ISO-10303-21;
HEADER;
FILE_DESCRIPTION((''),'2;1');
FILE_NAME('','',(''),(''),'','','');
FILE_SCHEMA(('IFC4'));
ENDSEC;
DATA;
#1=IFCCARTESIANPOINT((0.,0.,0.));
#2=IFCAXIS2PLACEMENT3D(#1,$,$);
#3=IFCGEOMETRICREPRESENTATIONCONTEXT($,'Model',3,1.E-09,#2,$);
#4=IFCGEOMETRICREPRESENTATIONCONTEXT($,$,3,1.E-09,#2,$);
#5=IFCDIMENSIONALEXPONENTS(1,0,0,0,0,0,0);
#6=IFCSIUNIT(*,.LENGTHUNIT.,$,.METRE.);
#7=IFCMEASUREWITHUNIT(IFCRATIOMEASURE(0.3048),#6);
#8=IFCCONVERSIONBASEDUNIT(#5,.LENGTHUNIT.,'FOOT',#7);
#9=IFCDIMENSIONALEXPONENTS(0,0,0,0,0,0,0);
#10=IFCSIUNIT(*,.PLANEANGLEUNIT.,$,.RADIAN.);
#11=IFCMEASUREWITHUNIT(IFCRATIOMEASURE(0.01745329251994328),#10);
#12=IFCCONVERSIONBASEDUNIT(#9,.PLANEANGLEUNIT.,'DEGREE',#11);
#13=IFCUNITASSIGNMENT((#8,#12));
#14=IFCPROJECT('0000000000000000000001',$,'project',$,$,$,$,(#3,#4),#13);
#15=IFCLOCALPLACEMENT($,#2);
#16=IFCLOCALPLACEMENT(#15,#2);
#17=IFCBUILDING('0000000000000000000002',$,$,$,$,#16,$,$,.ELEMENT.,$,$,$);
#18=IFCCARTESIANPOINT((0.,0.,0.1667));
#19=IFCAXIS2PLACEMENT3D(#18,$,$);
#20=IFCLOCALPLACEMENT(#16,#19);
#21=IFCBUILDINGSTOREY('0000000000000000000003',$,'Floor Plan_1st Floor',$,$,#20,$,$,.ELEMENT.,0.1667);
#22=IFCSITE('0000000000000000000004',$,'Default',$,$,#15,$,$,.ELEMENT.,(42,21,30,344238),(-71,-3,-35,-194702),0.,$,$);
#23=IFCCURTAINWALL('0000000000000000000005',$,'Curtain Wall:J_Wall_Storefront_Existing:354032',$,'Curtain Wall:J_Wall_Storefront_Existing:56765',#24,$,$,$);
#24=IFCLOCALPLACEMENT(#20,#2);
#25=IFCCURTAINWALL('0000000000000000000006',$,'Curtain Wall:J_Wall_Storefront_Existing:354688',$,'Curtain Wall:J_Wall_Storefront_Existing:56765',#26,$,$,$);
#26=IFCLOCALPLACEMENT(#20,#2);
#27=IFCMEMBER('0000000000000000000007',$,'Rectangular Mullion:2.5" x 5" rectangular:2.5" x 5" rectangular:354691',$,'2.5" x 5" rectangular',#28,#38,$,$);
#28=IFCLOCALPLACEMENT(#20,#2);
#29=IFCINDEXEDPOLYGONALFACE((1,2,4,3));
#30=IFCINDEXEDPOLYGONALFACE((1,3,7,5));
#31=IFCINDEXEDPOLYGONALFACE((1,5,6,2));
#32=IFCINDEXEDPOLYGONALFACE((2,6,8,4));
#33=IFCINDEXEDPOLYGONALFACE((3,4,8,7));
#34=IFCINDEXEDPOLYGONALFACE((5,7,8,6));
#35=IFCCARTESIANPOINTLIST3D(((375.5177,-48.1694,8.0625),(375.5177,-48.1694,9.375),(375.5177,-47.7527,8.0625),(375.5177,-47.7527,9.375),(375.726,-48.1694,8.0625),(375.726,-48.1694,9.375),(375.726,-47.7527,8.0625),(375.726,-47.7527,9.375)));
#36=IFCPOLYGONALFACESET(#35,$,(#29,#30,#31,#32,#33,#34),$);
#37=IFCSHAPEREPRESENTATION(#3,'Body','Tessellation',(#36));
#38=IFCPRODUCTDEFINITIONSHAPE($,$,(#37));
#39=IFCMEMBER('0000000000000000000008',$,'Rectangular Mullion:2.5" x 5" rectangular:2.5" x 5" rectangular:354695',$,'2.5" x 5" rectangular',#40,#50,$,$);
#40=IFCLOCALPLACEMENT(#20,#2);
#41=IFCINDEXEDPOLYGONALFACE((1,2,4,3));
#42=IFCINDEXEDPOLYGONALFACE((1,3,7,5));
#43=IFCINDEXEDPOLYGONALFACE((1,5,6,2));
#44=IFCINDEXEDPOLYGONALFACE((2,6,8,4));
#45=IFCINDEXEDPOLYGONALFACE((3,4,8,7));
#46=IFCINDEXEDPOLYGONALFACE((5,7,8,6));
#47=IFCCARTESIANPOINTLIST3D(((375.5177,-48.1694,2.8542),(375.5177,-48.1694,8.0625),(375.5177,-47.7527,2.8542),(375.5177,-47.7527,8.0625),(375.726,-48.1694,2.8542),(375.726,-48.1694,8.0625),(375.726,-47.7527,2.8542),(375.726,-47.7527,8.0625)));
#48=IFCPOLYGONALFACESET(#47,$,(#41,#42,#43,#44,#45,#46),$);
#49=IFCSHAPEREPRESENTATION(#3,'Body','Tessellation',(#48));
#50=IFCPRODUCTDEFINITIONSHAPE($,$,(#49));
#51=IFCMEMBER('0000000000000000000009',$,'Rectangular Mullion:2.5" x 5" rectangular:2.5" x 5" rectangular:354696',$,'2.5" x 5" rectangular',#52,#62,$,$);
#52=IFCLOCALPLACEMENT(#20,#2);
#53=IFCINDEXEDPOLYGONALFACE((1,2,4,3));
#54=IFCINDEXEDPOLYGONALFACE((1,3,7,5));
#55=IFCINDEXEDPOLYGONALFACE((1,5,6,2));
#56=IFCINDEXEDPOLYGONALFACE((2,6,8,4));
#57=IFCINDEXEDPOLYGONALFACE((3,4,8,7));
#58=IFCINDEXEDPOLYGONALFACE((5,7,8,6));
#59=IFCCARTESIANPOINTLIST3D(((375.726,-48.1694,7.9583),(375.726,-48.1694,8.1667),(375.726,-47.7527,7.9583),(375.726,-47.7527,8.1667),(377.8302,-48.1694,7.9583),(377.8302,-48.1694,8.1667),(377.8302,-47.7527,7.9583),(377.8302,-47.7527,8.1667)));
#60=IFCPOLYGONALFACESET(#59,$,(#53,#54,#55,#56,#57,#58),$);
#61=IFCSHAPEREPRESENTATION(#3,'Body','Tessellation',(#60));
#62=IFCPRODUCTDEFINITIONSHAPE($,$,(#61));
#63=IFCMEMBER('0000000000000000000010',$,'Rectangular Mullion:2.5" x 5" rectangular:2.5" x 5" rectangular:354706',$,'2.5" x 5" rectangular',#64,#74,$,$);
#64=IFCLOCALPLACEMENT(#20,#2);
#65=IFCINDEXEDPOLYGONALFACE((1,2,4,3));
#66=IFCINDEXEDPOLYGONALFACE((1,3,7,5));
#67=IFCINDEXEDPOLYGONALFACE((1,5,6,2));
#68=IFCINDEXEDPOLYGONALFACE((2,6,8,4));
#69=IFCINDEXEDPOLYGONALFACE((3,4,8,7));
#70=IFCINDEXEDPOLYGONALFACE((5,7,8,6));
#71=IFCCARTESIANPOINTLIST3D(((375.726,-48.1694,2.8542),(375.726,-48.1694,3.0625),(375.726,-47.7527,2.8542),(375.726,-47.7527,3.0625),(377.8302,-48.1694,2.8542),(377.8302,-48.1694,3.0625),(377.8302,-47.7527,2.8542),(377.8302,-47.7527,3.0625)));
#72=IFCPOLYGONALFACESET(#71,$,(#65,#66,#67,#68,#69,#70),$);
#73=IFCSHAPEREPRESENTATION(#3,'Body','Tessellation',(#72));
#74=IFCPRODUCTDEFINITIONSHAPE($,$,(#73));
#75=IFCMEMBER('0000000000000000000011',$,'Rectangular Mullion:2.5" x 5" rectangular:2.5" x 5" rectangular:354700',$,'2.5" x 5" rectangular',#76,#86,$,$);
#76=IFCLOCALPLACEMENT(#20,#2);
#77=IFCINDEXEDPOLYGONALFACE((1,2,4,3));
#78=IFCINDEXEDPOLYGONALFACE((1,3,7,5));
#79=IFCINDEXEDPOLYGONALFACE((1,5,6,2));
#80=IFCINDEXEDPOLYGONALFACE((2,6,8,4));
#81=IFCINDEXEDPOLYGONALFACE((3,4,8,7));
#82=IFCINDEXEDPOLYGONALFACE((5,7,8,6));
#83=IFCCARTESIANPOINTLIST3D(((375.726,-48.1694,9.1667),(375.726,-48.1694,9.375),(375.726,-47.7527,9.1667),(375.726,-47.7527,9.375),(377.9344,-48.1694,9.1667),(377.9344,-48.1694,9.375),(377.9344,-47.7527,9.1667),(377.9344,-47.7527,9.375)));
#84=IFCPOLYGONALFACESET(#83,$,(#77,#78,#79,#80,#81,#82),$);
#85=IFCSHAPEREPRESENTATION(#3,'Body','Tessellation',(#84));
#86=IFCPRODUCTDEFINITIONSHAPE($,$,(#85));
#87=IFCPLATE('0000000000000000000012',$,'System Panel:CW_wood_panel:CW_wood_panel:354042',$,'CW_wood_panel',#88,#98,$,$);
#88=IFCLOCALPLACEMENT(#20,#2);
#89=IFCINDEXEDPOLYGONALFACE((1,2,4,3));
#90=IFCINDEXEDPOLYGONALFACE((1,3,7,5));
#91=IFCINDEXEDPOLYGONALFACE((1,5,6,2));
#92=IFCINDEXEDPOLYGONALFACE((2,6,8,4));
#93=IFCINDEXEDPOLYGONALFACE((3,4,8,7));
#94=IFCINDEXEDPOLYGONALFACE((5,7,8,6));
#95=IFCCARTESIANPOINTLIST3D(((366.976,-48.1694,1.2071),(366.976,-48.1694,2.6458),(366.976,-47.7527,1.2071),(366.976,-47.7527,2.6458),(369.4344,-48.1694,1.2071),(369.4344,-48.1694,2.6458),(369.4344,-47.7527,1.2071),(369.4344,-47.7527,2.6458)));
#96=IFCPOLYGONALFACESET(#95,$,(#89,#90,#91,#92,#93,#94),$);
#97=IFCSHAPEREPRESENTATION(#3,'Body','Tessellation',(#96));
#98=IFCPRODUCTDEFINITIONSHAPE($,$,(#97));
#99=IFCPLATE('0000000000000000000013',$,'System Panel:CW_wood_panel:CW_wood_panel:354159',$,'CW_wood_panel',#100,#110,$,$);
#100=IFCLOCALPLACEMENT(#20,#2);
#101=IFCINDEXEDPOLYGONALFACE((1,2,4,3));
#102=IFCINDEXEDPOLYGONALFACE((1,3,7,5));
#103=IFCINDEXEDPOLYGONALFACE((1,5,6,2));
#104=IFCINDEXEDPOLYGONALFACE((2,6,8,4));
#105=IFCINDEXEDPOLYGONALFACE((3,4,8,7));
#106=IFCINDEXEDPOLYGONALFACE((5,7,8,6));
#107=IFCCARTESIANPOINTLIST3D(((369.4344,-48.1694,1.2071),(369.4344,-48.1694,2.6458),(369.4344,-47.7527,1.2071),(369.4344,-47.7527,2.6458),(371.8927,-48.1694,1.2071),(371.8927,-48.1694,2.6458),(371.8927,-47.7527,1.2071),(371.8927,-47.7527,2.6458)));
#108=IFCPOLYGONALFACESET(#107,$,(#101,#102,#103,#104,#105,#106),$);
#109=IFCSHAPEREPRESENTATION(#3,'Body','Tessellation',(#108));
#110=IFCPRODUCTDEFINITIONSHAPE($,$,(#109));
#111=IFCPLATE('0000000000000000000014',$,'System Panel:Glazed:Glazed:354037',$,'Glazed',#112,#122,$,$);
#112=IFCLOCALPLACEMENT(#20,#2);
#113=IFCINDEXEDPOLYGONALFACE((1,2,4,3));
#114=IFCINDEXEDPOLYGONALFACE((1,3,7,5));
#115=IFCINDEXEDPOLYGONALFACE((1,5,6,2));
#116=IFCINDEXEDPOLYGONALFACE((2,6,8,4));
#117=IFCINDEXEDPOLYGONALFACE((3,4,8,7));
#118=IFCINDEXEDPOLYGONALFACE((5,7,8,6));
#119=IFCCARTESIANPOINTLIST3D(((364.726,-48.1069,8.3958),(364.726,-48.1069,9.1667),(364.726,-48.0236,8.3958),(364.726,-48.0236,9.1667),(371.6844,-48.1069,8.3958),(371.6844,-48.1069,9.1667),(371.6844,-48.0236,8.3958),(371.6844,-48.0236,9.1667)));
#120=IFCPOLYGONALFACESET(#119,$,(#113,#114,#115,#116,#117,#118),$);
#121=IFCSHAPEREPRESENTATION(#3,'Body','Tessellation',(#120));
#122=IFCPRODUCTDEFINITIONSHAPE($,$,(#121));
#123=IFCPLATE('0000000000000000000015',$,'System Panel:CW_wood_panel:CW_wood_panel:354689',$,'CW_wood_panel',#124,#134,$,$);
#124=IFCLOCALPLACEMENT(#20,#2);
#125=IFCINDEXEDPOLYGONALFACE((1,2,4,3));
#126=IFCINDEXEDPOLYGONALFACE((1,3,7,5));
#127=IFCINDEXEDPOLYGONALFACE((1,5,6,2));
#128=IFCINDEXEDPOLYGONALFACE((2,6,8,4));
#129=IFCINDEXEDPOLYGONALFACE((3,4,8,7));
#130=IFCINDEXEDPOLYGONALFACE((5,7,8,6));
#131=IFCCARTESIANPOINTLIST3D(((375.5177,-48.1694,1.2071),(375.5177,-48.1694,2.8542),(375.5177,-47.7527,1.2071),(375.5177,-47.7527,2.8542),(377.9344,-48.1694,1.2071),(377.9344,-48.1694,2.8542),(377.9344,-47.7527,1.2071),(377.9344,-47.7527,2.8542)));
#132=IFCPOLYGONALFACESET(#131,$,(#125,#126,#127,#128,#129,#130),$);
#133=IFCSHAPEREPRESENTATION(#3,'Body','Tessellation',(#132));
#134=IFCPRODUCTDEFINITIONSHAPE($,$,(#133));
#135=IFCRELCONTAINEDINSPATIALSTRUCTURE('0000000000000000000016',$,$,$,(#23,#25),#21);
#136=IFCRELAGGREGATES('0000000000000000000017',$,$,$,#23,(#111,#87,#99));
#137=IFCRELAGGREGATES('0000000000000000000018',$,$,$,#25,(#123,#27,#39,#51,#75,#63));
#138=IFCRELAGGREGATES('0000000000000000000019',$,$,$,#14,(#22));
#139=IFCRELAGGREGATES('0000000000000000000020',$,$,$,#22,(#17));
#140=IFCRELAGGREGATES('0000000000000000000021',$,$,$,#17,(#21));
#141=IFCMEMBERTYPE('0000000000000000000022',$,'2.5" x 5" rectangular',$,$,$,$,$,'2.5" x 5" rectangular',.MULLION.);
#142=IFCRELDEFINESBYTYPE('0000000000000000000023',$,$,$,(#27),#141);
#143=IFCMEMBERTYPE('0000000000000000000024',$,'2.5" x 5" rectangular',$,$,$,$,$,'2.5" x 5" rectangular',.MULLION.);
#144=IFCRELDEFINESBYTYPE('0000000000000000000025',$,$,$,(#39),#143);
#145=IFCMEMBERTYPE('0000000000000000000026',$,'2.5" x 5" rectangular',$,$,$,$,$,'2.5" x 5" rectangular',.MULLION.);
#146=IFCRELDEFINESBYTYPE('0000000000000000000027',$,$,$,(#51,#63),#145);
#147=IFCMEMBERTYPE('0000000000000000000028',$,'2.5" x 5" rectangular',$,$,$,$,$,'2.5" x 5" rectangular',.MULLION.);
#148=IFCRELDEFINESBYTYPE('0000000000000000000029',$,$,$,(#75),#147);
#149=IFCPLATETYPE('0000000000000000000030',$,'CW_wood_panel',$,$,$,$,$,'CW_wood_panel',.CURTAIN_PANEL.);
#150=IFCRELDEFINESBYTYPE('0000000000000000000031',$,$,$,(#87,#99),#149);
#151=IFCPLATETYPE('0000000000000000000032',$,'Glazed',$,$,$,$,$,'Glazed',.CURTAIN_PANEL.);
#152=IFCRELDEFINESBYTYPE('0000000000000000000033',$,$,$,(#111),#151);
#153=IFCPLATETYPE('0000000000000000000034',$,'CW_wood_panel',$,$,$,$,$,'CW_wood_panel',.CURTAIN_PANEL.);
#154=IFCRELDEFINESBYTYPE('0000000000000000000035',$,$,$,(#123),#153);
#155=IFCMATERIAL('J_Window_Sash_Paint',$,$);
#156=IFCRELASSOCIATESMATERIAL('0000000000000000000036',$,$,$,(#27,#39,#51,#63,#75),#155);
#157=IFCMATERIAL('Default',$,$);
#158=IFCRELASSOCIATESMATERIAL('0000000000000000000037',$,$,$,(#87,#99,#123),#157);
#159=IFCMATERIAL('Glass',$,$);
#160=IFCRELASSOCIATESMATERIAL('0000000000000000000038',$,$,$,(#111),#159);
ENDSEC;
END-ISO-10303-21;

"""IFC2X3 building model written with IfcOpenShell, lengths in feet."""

from ifc_helpers import new_model, entity, si_unit, converted_unit, frame, origin, origin_2d_with_axis, place, context, project, spatial, rectangle, extrude, source, transform, mapped, material, type_object, type_shapes, element, aggregate, save


model = new_model("IFC2X3")

# Units and contexts
model_context = context("Model", 3, precision=1e-09, world=origin())
context_of_model = context(None, 3, precision=1e-09, world=origin())
ifc_project = project(units=[converted_unit("LENGTHUNIT", "FOOT", entity("IfcRatioMeasure", 0.3048), si_unit("LENGTHUNIT", "METRE"), dimensions=[1, 0, 0, 0, 0, 0, 0]), converted_unit("PLANEANGLEUNIT", "DEGREE", entity("IfcRatioMeasure", 0.01745329251994328), si_unit("PLANEANGLEUNIT", "RADIAN"), dimensions=[0, 0, 0, 0, 0, 0, 0])], contexts=[model_context, context_of_model])

# Site, building, storey
site_placement = place(None, origin())
site = spatial("IfcSite", under=ifc_project, at=site_placement, Name="Default", CompositionType="ELEMENT", RefLatitude=(42, 21, 30, 344238), RefLongitude=(-71, -3, -35, -194702), RefElevation=0.0)
building_placement = place(site_placement, origin())
building = spatial("IfcBuilding", under=site, at=building_placement, CompositionType="ELEMENT")
storey_placement = place(building_placement, frame((0.0, 0.0, 0.1667)))
storey = spatial("IfcBuildingStorey", under=building, at=storey_placement, Name="Floor Plan_1st Floor", CompositionType="ELEMENT", Elevation=0.1667)

# Curtain walls, members
curtain_wall_1_placement = place(storey_placement, origin())
curtain_wall_1 = element("IfcCurtainWall", 1, at=curtain_wall_1_placement, inside=storey, Name="Curtain Wall:J_Wall_Storefront_Existing:354032", ObjectType="Curtain Wall:J_Wall_Storefront_Existing:56765")
ifc_material_1 = material(Name="J_Window_Sash_Paint")
curtain_wall_2_placement = place(storey_placement, origin())
curtain_wall_2 = element("IfcCurtainWall", 2, at=curtain_wall_2_placement, inside=storey, Name="Curtain Wall:J_Wall_Storefront_Existing:354688", ObjectType="Curtain Wall:J_Wall_Storefront_Existing:56765")
member_type_1 = type_object("IfcMemberType", Name="2.5\" x 5\" rectangular", ElementType="2.5\" x 5\" rectangular", PredefinedType="MULLION")
shared_shape_1 = source(origin(), model_context, "Body", "SweptSolid", [
    extrude(rectangle(XDim=0.2083, YDim=0.4167, at=origin_2d_with_axis()), frame((-0.1042, 0.0, -1.3125), z_axis=(0.0, 0.0, 1.0), x_axis=(-1.0, 0.0, 0.0)), (0.0, 0.0, 1.0), 1.3125),
])
type_shapes(member_type_1, [shared_shape_1])
member_1_placement = place(storey_placement, frame((375.5177, -47.9611, 9.375), z_axis=(0.0, 0.0, 1.0), x_axis=(-1.0, 0.0, 0.0)))
member_1 = element("IfcMember", 3, at=member_1_placement, type_object=member_type_1, material=ifc_material_1, Name="Rectangular Mullion:2.5\" x 5\" rectangular:2.5\" x 5\" rectangular:354691", ObjectType="2.5\" x 5\" rectangular", context=model_context, shape_type="MappedRepresentation", body=[
    mapped(shared_shape_1, transform((0.0, 0.0, 0.0), scale=1.0)),
])
member_type_2 = type_object("IfcMemberType", Name="2.5\" x 5\" rectangular", ElementType="2.5\" x 5\" rectangular", PredefinedType="MULLION")
shared_shape_2 = source(origin(), model_context, "Body", "SweptSolid", [
    extrude(rectangle(XDim=0.2083, YDim=0.4167, at=origin_2d_with_axis()), frame((-0.1042, 0.0, -5.2083), z_axis=(0.0, 0.0, 1.0), x_axis=(-1.0, 0.0, 0.0)), (0.0, 0.0, 1.0), 5.2083),
])
type_shapes(member_type_2, [shared_shape_2])
member_2_placement = place(storey_placement, frame((375.5177, -47.9611, 8.0625), z_axis=(0.0, 0.0, 1.0), x_axis=(-1.0, 0.0, 0.0)))
member_2 = element("IfcMember", 4, at=member_2_placement, type_object=member_type_2, material=ifc_material_1, Name="Rectangular Mullion:2.5\" x 5\" rectangular:2.5\" x 5\" rectangular:354695", ObjectType="2.5\" x 5\" rectangular", context=model_context, shape_type="MappedRepresentation", body=[
    mapped(shared_shape_2, transform((0.0, 0.0, 0.0), scale=1.0)),
])
member_type_3 = type_object("IfcMemberType", Name="2.5\" x 5\" rectangular", ElementType="2.5\" x 5\" rectangular", PredefinedType="MULLION")
shared_shape_3 = source(origin(), model_context, "Body", "SweptSolid", [
    extrude(rectangle(XDim=0.2083, YDim=0.4167, at=origin_2d_with_axis()), frame((0.0, 0.0, -2.1042), z_axis=(0.0, 0.0, 1.0), x_axis=(-1.0, 0.0, 0.0)), (0.0, 0.0, 1.0), 2.1042),
])
type_shapes(member_type_3, [shared_shape_3])
member_3_placement = place(storey_placement, frame((377.8302, -47.9611, 8.0625), z_axis=(1.0, 0.0, 0.0), x_axis=(0.0, 0.0, 1.0)))
member_3 = element("IfcMember", 5, at=member_3_placement, type_object=member_type_3, material=ifc_material_1, Name="Rectangular Mullion:2.5\" x 5\" rectangular:2.5\" x 5\" rectangular:354696", ObjectType="2.5\" x 5\" rectangular", context=model_context, shape_type="MappedRepresentation", body=[
    mapped(shared_shape_3, transform((0.0, 0.0, 0.0), scale=1.0)),
])
member_4_placement = place(storey_placement, frame((377.8302, -47.9611, 2.9583), z_axis=(1.0, 0.0, 0.0), x_axis=(0.0, 0.0, 1.0)))
member_4 = element("IfcMember", 6, at=member_4_placement, type_object=member_type_3, material=ifc_material_1, Name="Rectangular Mullion:2.5\" x 5\" rectangular:2.5\" x 5\" rectangular:354706", ObjectType="2.5\" x 5\" rectangular", context=model_context, shape_type="MappedRepresentation", body=[
    mapped(shared_shape_3, transform((0.0, 0.0, 0.0), scale=1.0)),
])
member_type_4 = type_object("IfcMemberType", Name="2.5\" x 5\" rectangular", ElementType="2.5\" x 5\" rectangular", PredefinedType="MULLION")
shared_shape_4 = source(origin(), model_context, "Body", "SweptSolid", [
    extrude(rectangle(XDim=0.2083, YDim=0.4167, at=origin_2d_with_axis()), frame((-0.1042, 0.0, -2.2083), z_axis=(0.0, 0.0, 1.0), x_axis=(-1.0, 0.0, 0.0)), (0.0, 0.0, 1.0), 2.2083),
])
type_shapes(member_type_4, [shared_shape_4])
member_5_placement = place(storey_placement, frame((377.9344, -47.9611, 9.375), z_axis=(1.0, 0.0, 0.0), x_axis=(0.0, 0.0, 1.0)))
member_5 = element("IfcMember", 7, at=member_5_placement, type_object=member_type_4, material=ifc_material_1, Name="Rectangular Mullion:2.5\" x 5\" rectangular:2.5\" x 5\" rectangular:354700", ObjectType="2.5\" x 5\" rectangular", context=model_context, shape_type="MappedRepresentation", body=[
    mapped(shared_shape_4, transform((0.0, 0.0, 0.0), scale=1.0)),
])

# Plates
ifc_material_2 = material(Name="Default")
plate_type_1 = type_object("IfcPlateType", Name="CW_wood_panel", ElementType="CW_wood_panel", PredefinedType="CURTAIN_PANEL")
shared_shape_5 = source(origin(), model_context, "Body", "SweptSolid", [
    extrude(rectangle(XDim=0.4167, YDim=2.4583, at=origin_2d_with_axis()), frame((0.0, 0.0, 0.0), z_axis=(0.0, 0.0, 1.0), x_axis=(0.0, 1.0, 0.0)), (0.0, 0.0, 1.0), 1.4388),
])
type_shapes(plate_type_1, [shared_shape_5])
plate_1_placement = place(storey_placement, frame((368.2052, -47.9611, 1.2071)))
plate_1 = element("IfcPlate", 8, at=plate_1_placement, type_object=plate_type_1, material=ifc_material_2, Name="System Panel:CW_wood_panel:CW_wood_panel:354042", ObjectType="CW_wood_panel", context=model_context, shape_type="MappedRepresentation", body=[
    mapped(shared_shape_5, transform((0.0, 0.0, 0.0), scale=1.0)),
])
plate_2_placement = place(storey_placement, frame((370.6635, -47.9611, 1.2071)))
plate_2 = element("IfcPlate", 9, at=plate_2_placement, type_object=plate_type_1, material=ifc_material_2, Name="System Panel:CW_wood_panel:CW_wood_panel:354159", ObjectType="CW_wood_panel", context=model_context, shape_type="MappedRepresentation", body=[
    mapped(shared_shape_5, transform((0.0, 0.0, 0.0), scale=1.0)),
])
ifc_material_3 = material(Name="Glass")
plate_type_2 = type_object("IfcPlateType", Name="Glazed", ElementType="Glazed", PredefinedType="CURTAIN_PANEL")
shared_shape_6 = source(origin(), model_context, "Body", "SweptSolid", [
    extrude(rectangle(XDim=0.7708, YDim=6.9583, at=origin_2d_with_axis()), frame((0.0, -0.1458, 0.3854), z_axis=(0.0, 1.0, 0.0), x_axis=(0.0, 0.0, 1.0)), (0.0, 0.0, 1.0), 0.0833),
])
type_shapes(plate_type_2, [shared_shape_6])
plate_3_placement = place(storey_placement, frame((368.2052, -47.9611, 8.3958)))
plate_3 = element("IfcPlate", 10, at=plate_3_placement, type_object=plate_type_2, material=ifc_material_3, Name="System Panel:Glazed:Glazed:354037", ObjectType="Glazed", context=model_context, shape_type="MappedRepresentation", body=[
    mapped(shared_shape_6, transform((0.0, 0.0, 0.0), scale=1.0)),
])
aggregate(curtain_wall_1, [plate_3, plate_1, plate_2])
plate_type_3 = type_object("IfcPlateType", Name="CW_wood_panel", ElementType="CW_wood_panel", PredefinedType="CURTAIN_PANEL")
shared_shape_7 = source(origin(), model_context, "Body", "SweptSolid", [
    extrude(rectangle(XDim=0.4167, YDim=2.4167, at=origin_2d_with_axis()), frame((0.0, 0.0, 0.0), z_axis=(0.0, 0.0, 1.0), x_axis=(0.0, 1.0, 0.0)), (0.0, 0.0, 1.0), 1.6471),
])
type_shapes(plate_type_3, [shared_shape_7])
plate_4_placement = place(storey_placement, frame((376.726, -47.9611, 1.2071)))
plate_4 = element("IfcPlate", 11, at=plate_4_placement, type_object=plate_type_3, material=ifc_material_2, Name="System Panel:CW_wood_panel:CW_wood_panel:354689", ObjectType="CW_wood_panel", context=model_context, shape_type="MappedRepresentation", body=[
    mapped(shared_shape_7, transform((0.0, 0.0, 0.0), scale=1.0)),
])
aggregate(curtain_wall_2, [plate_4, member_1, member_2, member_3, member_5, member_4])

save(model, "model.ifc")
